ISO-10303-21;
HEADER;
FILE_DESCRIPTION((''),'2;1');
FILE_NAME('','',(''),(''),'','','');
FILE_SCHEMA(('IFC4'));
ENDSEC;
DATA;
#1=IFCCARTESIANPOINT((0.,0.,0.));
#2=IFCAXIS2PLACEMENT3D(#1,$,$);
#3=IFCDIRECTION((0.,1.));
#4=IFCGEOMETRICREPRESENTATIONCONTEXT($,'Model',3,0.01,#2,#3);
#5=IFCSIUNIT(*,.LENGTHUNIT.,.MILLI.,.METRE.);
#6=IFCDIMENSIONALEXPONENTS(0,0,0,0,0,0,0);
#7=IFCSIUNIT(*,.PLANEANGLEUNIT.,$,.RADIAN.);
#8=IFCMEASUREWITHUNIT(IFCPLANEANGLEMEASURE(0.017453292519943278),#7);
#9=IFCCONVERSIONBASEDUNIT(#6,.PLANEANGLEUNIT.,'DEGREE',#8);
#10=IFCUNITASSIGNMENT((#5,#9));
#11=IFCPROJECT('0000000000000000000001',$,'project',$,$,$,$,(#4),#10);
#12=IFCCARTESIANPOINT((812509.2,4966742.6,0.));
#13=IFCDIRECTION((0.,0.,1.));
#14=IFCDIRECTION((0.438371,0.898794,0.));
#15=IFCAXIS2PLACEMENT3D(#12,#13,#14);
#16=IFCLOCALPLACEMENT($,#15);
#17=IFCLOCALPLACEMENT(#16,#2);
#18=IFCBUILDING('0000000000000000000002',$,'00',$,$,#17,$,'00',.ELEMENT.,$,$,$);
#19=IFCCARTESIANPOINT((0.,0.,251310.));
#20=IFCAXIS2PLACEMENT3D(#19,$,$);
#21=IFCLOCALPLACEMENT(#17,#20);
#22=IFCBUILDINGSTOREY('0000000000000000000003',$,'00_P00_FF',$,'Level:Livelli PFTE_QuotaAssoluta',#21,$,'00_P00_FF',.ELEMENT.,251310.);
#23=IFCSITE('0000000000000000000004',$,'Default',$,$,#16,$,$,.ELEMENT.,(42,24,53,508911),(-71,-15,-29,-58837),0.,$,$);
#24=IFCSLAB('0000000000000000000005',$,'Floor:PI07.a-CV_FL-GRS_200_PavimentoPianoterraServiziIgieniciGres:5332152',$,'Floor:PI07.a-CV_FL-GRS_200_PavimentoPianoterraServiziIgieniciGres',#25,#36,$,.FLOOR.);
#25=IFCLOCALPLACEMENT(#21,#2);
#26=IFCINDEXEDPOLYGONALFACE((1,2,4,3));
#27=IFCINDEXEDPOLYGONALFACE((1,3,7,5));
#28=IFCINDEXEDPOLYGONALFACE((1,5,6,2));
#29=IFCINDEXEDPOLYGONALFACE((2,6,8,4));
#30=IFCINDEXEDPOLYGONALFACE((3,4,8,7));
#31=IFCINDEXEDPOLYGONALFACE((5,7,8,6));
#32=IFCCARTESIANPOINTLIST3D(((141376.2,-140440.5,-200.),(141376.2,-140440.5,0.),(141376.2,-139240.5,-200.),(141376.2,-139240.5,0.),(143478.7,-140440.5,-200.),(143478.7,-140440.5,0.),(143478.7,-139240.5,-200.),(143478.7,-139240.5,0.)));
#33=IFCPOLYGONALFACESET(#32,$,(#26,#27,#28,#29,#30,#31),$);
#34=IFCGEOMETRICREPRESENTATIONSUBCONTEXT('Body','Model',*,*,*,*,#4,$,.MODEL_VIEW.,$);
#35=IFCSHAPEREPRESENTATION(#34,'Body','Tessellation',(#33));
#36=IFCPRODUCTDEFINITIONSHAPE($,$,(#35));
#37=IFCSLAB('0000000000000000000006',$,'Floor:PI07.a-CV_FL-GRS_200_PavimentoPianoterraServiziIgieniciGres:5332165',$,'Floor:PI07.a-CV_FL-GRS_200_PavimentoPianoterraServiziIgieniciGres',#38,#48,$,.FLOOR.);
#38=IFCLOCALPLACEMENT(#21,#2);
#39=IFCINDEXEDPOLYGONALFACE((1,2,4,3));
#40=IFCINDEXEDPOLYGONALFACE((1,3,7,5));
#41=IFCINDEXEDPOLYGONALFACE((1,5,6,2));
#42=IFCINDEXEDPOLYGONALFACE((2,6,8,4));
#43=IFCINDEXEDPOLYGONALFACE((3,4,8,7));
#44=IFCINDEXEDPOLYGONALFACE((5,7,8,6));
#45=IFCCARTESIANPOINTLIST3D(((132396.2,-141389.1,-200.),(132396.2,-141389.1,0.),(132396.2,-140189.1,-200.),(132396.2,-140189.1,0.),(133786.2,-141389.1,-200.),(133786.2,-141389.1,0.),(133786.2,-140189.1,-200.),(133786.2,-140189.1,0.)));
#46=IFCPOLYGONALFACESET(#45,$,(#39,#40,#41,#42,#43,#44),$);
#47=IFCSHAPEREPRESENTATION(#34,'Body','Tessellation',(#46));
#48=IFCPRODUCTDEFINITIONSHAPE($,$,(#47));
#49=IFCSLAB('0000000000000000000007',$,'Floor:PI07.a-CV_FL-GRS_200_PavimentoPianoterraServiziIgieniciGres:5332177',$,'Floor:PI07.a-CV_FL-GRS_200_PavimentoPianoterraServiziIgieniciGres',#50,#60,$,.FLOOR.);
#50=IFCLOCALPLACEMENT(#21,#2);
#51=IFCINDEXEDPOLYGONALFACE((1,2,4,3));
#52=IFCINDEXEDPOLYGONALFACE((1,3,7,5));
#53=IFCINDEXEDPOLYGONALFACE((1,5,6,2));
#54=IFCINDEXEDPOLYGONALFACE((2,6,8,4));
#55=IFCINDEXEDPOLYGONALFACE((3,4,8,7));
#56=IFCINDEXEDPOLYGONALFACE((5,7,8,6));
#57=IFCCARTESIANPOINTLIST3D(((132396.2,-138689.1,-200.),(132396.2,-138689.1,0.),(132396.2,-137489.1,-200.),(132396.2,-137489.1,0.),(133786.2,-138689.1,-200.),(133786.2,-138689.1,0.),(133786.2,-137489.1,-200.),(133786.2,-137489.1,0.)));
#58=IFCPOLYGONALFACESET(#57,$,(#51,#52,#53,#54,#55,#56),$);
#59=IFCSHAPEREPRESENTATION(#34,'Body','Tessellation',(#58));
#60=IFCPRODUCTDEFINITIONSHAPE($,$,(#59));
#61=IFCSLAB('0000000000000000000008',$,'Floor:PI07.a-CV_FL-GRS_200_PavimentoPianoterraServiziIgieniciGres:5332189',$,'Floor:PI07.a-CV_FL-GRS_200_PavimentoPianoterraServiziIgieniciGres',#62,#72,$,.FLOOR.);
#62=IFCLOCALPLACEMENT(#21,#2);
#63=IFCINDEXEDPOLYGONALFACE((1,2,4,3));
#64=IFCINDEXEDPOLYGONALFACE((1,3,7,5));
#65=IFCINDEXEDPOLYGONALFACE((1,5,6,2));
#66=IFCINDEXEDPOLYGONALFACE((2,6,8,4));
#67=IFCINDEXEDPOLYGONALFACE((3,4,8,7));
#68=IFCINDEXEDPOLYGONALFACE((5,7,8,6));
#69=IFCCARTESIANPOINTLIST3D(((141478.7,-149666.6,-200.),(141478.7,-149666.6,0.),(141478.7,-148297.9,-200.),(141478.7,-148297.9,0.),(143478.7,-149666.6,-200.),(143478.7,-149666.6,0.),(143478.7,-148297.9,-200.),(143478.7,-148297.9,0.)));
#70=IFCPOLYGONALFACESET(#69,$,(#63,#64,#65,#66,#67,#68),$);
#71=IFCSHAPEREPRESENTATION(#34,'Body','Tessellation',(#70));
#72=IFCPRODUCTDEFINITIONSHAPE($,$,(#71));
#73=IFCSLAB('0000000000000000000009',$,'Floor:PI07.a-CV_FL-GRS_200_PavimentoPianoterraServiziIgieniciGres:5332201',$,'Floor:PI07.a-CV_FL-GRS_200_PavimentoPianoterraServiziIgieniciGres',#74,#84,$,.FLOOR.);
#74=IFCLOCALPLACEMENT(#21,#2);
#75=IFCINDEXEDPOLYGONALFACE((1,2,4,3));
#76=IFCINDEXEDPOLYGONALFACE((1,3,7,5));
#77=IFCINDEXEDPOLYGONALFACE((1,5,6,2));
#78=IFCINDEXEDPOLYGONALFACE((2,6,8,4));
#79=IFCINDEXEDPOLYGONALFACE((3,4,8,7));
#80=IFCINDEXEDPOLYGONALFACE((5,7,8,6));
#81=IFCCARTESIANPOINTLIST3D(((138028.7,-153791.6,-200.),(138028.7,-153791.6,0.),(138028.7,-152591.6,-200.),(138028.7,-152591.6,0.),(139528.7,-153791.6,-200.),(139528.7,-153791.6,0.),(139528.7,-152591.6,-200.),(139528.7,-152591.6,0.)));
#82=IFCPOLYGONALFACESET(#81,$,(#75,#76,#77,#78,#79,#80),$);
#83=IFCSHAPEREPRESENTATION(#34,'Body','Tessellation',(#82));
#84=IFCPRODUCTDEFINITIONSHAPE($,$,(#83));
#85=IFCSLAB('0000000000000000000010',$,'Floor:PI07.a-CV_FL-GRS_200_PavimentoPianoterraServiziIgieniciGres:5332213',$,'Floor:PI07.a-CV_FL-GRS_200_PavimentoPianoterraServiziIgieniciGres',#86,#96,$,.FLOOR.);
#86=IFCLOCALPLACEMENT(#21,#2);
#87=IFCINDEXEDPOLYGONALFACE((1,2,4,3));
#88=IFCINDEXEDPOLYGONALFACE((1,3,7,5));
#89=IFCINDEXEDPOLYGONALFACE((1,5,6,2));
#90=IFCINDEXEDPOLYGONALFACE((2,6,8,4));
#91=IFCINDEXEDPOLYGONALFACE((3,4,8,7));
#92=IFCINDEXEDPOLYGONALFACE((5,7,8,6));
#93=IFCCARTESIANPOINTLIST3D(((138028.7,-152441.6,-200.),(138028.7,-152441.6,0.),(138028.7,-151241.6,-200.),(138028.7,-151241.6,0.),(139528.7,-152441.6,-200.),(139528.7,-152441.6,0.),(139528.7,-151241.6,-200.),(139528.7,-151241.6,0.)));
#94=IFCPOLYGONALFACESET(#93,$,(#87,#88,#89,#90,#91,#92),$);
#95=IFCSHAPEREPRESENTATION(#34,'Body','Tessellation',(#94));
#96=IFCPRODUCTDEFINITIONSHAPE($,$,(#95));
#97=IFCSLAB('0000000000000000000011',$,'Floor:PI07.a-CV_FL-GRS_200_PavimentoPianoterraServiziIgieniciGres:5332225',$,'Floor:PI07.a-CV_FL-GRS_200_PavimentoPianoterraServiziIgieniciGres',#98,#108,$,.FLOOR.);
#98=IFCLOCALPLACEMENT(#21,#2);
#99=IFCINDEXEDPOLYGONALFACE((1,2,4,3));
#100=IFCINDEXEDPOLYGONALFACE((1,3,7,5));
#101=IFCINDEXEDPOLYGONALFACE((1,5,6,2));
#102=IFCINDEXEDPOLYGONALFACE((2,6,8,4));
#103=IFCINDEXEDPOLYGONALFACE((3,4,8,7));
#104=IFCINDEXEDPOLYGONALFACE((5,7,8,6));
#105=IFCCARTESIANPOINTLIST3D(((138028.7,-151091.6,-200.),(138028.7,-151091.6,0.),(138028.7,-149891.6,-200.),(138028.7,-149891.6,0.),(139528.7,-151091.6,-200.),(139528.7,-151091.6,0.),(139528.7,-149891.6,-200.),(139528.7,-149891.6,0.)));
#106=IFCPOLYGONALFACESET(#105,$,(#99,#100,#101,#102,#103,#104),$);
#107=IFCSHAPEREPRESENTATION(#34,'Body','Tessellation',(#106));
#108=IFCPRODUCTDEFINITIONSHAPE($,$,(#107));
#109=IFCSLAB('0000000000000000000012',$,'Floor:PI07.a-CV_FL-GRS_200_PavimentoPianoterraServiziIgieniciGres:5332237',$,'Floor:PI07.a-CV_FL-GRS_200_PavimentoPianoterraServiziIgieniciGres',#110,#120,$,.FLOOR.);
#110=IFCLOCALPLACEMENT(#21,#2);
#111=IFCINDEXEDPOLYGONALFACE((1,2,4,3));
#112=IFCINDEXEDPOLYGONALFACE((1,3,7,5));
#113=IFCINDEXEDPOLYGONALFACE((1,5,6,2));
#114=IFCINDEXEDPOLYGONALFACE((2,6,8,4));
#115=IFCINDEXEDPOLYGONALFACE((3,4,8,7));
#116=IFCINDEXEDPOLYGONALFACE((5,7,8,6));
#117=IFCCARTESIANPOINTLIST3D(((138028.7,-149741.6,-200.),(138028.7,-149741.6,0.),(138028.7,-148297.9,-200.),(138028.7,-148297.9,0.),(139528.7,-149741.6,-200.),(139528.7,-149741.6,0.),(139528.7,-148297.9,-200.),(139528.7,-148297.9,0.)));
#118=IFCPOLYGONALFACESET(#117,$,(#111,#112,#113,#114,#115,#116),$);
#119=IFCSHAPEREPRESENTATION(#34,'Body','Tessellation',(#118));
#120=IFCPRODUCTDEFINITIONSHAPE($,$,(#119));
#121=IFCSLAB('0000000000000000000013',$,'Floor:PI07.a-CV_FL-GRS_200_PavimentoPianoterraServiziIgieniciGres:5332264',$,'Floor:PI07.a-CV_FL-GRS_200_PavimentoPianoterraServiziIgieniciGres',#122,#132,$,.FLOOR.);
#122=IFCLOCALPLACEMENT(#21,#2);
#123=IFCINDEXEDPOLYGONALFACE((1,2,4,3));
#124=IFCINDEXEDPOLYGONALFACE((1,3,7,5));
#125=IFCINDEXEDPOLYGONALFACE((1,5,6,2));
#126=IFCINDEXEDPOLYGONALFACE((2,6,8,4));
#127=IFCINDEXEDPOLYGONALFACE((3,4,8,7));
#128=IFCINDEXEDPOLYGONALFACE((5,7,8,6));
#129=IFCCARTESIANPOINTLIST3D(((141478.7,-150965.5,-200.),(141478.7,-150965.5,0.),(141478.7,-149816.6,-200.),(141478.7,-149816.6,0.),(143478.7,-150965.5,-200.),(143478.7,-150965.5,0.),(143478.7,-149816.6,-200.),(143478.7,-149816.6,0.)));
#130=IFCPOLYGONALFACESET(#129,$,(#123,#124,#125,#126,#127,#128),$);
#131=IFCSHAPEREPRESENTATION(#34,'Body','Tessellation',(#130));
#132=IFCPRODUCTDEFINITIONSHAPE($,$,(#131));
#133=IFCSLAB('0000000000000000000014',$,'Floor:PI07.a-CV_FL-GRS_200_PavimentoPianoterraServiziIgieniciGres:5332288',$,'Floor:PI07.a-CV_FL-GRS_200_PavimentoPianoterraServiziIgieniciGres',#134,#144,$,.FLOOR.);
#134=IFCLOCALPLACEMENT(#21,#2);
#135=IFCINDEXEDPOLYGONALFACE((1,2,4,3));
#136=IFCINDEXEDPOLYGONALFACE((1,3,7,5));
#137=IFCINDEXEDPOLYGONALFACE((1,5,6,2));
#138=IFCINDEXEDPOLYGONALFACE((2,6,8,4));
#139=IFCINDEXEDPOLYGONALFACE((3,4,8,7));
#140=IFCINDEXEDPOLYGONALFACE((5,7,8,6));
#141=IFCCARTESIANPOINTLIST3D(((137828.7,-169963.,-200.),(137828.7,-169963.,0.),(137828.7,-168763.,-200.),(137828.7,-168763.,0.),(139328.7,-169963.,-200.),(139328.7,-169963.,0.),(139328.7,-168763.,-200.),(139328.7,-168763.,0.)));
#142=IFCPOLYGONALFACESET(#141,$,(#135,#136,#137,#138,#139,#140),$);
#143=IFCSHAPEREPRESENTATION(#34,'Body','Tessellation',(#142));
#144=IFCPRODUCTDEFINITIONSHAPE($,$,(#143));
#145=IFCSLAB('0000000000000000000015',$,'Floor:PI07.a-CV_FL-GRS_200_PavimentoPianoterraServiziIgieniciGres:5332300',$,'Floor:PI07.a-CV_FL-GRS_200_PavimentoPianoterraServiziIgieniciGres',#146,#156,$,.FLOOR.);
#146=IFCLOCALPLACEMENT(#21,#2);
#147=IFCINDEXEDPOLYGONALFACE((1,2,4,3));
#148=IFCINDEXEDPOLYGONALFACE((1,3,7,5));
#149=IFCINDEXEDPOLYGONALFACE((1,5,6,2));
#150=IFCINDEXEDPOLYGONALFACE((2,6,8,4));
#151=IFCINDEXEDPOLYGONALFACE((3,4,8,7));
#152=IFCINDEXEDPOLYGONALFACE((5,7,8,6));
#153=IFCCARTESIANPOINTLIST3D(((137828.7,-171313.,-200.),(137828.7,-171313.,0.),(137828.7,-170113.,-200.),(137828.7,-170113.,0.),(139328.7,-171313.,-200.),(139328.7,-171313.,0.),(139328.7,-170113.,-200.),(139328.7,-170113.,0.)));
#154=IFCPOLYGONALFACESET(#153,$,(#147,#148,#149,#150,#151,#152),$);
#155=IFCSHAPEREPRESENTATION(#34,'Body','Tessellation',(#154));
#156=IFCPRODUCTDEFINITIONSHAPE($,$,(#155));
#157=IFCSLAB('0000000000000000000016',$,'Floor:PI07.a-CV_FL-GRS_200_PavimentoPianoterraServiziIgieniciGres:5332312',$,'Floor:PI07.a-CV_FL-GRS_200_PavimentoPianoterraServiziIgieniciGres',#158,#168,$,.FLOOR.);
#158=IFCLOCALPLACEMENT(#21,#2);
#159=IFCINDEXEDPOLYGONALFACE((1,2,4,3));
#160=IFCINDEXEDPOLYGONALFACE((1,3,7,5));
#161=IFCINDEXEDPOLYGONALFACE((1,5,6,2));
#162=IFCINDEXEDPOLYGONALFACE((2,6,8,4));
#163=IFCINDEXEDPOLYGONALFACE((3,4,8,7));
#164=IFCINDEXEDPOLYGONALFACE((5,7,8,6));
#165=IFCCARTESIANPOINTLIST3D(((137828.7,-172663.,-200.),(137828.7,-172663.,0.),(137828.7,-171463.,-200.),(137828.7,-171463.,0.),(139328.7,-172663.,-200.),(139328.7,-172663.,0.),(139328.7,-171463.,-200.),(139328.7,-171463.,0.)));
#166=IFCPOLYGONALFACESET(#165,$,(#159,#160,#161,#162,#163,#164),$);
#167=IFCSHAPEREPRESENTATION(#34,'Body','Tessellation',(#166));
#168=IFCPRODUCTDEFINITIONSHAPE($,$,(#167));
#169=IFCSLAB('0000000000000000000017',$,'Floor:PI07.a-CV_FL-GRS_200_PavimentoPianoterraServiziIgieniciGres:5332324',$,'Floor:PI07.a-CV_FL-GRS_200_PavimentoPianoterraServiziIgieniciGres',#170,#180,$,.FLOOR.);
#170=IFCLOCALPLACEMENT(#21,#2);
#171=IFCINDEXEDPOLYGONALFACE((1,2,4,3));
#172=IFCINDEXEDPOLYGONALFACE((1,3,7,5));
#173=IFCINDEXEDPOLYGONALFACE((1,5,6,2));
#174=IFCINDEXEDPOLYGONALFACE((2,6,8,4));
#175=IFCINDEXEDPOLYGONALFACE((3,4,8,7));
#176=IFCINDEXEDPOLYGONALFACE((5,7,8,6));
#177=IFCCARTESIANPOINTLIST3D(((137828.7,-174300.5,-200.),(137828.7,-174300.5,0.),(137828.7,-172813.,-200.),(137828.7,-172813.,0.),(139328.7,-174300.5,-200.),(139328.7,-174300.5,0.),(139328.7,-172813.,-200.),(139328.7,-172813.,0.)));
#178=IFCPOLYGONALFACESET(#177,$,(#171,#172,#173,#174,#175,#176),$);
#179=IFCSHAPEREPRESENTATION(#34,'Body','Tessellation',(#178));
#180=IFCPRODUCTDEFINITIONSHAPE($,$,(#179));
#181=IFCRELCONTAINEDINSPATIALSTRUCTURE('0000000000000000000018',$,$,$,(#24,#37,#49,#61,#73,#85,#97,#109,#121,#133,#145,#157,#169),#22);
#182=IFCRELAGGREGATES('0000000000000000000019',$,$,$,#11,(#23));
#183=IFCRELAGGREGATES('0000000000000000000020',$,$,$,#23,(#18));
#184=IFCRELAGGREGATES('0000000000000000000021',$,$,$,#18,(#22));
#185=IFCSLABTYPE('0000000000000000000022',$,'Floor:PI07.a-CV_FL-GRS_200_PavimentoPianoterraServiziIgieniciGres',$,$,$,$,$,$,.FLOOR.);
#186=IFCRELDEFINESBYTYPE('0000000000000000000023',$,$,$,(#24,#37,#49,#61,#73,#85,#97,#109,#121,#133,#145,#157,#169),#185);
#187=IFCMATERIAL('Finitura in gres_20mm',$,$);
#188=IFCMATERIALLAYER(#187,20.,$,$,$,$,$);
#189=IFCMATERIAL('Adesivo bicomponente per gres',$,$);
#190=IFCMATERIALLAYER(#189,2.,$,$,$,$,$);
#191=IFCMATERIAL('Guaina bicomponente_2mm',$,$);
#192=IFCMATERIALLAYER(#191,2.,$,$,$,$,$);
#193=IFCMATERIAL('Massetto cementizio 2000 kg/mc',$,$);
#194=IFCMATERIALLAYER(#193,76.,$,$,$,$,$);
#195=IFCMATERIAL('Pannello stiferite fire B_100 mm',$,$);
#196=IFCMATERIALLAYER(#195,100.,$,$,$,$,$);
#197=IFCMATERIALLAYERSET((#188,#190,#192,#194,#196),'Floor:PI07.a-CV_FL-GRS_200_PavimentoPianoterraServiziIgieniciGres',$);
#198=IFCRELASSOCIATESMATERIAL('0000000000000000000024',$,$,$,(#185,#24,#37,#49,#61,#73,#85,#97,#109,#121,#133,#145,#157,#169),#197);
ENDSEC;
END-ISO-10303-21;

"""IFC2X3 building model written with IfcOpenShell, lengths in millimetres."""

from ifc_helpers import new_model, entity, si_unit, converted_unit, direction, frame, frame_2d, origin, origin_2d_with_axis, place, context, subcontext, project, spatial, rectangle, extrude, material, layer, layer_set, layer_usage, type_object, element, save


model = new_model("IFC2X3")

# Units and contexts
model_context = context("Model", 3, precision=0.01, world=origin(), true_north=direction((0.0, 1.0)))
body_context = subcontext(model_context, "Body", "Model", "MODEL_VIEW")
ifc_project = project(units=[si_unit("LENGTHUNIT", "METRE", prefix="MILLI"), converted_unit("PLANEANGLEUNIT", "DEGREE", entity("IfcPlaneAngleMeasure", 0.017453292519943278), si_unit("PLANEANGLEUNIT", "RADIAN"), dimensions=[0, 0, 0, 0, 0, 0, 0])], contexts=[model_context])

# Site, building, storey
site_placement = place(None, frame((812509.2, 4966742.6, 0.0), z_axis=(0.0, 0.0, 1.0), x_axis=(0.438371, 0.898794, 0.0)))
site = spatial("IfcSite", under=ifc_project, at=site_placement, Name="Default", CompositionType="ELEMENT", RefLatitude=(42, 24, 53, 508911), RefLongitude=(-71, -15, -29, -58837), RefElevation=0.0)
building_placement = place(site_placement, origin())
building = spatial("IfcBuilding", under=site, at=building_placement, Name="00", LongName="00", CompositionType="ELEMENT")
storey_placement = place(building_placement, frame((0.0, 0.0, 251310.0)))
storey = spatial("IfcBuildingStorey", under=building, at=storey_placement, Name="00_P00_FF", ObjectType="Level:Livelli PFTE_QuotaAssoluta", LongName="00_P00_FF", CompositionType="ELEMENT", Elevation=251310.0)

# Slabs
ifc_material_1 = material(Name="Finitura in gres_20mm")
ifc_layer_1 = layer(ifc_material_1, 20.0)
ifc_material_2 = material(Name="Adesivo bicomponente per gres")
ifc_layer_2 = layer(ifc_material_2, 2.0)
ifc_material_3 = material(Name="Guaina bicomponente_2mm")
ifc_layer_3 = layer(ifc_material_3, 2.0)
ifc_material_4 = material(Name="Massetto cementizio 2000 kg/mc")
ifc_layer_4 = layer(ifc_material_4, 76.0)
ifc_material_5 = material(Name="Pannello stiferite fire B_100 mm")
ifc_layer_5 = layer(ifc_material_5, 100.0)
ifc_layer_set = layer_set([ifc_layer_1, ifc_layer_2, ifc_layer_3, ifc_layer_4, ifc_layer_5], Name="Floor:PI07.a-CV_FL-GRS_200_PavimentoPianoterraServiziIgieniciGres")
ifc_layer_usage_1 = layer_usage(ifc_layer_set, "AXIS3", "POSITIVE", 0.0)
slab_type = type_object("IfcSlabType", Name="Floor:PI07.a-CV_FL-GRS_200_PavimentoPianoterraServiziIgieniciGres", PredefinedType="FLOOR", material=ifc_layer_set)
slab_1_placement = place(storey_placement, origin())
element("IfcSlab", 1, at=slab_1_placement, inside=storey, type_object=slab_type, material=ifc_layer_usage_1, Name="Floor:PI07.a-CV_FL-GRS_200_PavimentoPianoterraServiziIgieniciGres:5332152", ObjectType="Floor:PI07.a-CV_FL-GRS_200_PavimentoPianoterraServiziIgieniciGres", PredefinedType="FLOOR", context=body_context, shape_type="SweptSolid", body=[
    extrude(rectangle(XDim=1200.0, YDim=2102.5, at=origin_2d_with_axis()), frame((142427.4, -139840.5, 0.0), z_axis=(0.0, 0.0, -1.0), x_axis=(0.0, 1.0, 0.0)), (0.0, 0.0, 1.0), 200.0),
])
ifc_layer_usage_2 = layer_usage(ifc_layer_set, "AXIS3", "POSITIVE", 0.0)
slab_2_placement = place(storey_placement, origin())
element("IfcSlab", 2, at=slab_2_placement, inside=storey, type_object=slab_type, material=ifc_layer_usage_2, Name="Floor:PI07.a-CV_FL-GRS_200_PavimentoPianoterraServiziIgieniciGres:5332165", ObjectType="Floor:PI07.a-CV_FL-GRS_200_PavimentoPianoterraServiziIgieniciGres", PredefinedType="FLOOR", context=body_context, shape_type="SweptSolid", body=[
    extrude(rectangle(XDim=1200.0, YDim=1390.0, at=frame_2d((0.0, 0.0), x_axis=(1.0, 0.0))), frame((133091.2, -140789.1, 0.0), z_axis=(0.0, 0.0, -1.0), x_axis=(0.0, 1.0, 0.0)), (0.0, 0.0, 1.0), 200.0),
])
ifc_layer_usage_3 = layer_usage(ifc_layer_set, "AXIS3", "POSITIVE", 0.0)
slab_3_placement = place(storey_placement, origin())
element("IfcSlab", 3, at=slab_3_placement, inside=storey, type_object=slab_type, material=ifc_layer_usage_3, Name="Floor:PI07.a-CV_FL-GRS_200_PavimentoPianoterraServiziIgieniciGres:5332177", ObjectType="Floor:PI07.a-CV_FL-GRS_200_PavimentoPianoterraServiziIgieniciGres", PredefinedType="FLOOR", context=body_context, shape_type="SweptSolid", body=[
    extrude(rectangle(XDim=1200.0, YDim=1390.0, at=origin_2d_with_axis()), frame((133091.2, -138089.1, 0.0), z_axis=(0.0, 0.0, -1.0), x_axis=(0.0, 1.0, 0.0)), (0.0, 0.0, 1.0), 200.0),
])
ifc_layer_usage_4 = layer_usage(ifc_layer_set, "AXIS3", "POSITIVE", 0.0)
slab_4_placement = place(storey_placement, origin())
element("IfcSlab", 4, at=slab_4_placement, inside=storey, type_object=slab_type, material=ifc_layer_usage_4, Name="Floor:PI07.a-CV_FL-GRS_200_PavimentoPianoterraServiziIgieniciGres:5332189", ObjectType="Floor:PI07.a-CV_FL-GRS_200_PavimentoPianoterraServiziIgieniciGres", PredefinedType="FLOOR", context=body_context, shape_type="SweptSolid", body=[
    extrude(rectangle(XDim=1368.7, YDim=2000.0, at=frame_2d((0.0, 0.0), x_axis=(1.0, 0.0))), frame((142478.7, -148982.3, 0.0), z_axis=(0.0, 0.0, -1.0), x_axis=(0.0, 1.0, 0.0)), (0.0, 0.0, 1.0), 200.0),
])
ifc_layer_usage_5 = layer_usage(ifc_layer_set, "AXIS3", "POSITIVE", 0.0)
slab_5_placement = place(storey_placement, origin())
element("IfcSlab", 5, at=slab_5_placement, inside=storey, type_object=slab_type, material=ifc_layer_usage_5, Name="Floor:PI07.a-CV_FL-GRS_200_PavimentoPianoterraServiziIgieniciGres:5332201", ObjectType="Floor:PI07.a-CV_FL-GRS_200_PavimentoPianoterraServiziIgieniciGres", PredefinedType="FLOOR", context=body_context, shape_type="SweptSolid", body=[
    extrude(rectangle(XDim=1200.0, YDim=1500.0, at=frame_2d((0.0, 0.0), x_axis=(1.0, 0.0))), frame((138778.7, -153191.6, 0.0), z_axis=(0.0, 0.0, -1.0), x_axis=(0.0, 1.0, 0.0)), (0.0, 0.0, 1.0), 200.0),
])
ifc_layer_usage_6 = layer_usage(ifc_layer_set, "AXIS3", "POSITIVE", 0.0)
slab_6_placement = place(storey_placement, origin())
element("IfcSlab", 6, at=slab_6_placement, inside=storey, type_object=slab_type, material=ifc_layer_usage_6, Name="Floor:PI07.a-CV_FL-GRS_200_PavimentoPianoterraServiziIgieniciGres:5332213", ObjectType="Floor:PI07.a-CV_FL-GRS_200_PavimentoPianoterraServiziIgieniciGres", PredefinedType="FLOOR", context=body_context, shape_type="SweptSolid", body=[
    extrude(rectangle(XDim=1200.0, YDim=1500.0, at=origin_2d_with_axis()), frame((138778.7, -151841.6, 0.0), z_axis=(0.0, 0.0, -1.0), x_axis=(0.0, 1.0, 0.0)), (0.0, 0.0, 1.0), 200.0),
])
ifc_layer_usage_7 = layer_usage(ifc_layer_set, "AXIS3", "POSITIVE", 0.0)
slab_7_placement = place(storey_placement, origin())
element("IfcSlab", 7, at=slab_7_placement, inside=storey, type_object=slab_type, material=ifc_layer_usage_7, Name="Floor:PI07.a-CV_FL-GRS_200_PavimentoPianoterraServiziIgieniciGres:5332225", ObjectType="Floor:PI07.a-CV_FL-GRS_200_PavimentoPianoterraServiziIgieniciGres", PredefinedType="FLOOR", context=body_context, shape_type="SweptSolid", body=[
    extrude(rectangle(XDim=1200.0, YDim=1500.0, at=origin_2d_with_axis()), frame((138778.7, -150491.6, 0.0), z_axis=(0.0, 0.0, -1.0), x_axis=(0.0, 1.0, 0.0)), (0.0, 0.0, 1.0), 200.0),
])
ifc_layer_usage_8 = layer_usage(ifc_layer_set, "AXIS3", "POSITIVE", 0.0)
slab_8_placement = place(storey_placement, origin())
element("IfcSlab", 8, at=slab_8_placement, inside=storey, type_object=slab_type, material=ifc_layer_usage_8, Name="Floor:PI07.a-CV_FL-GRS_200_PavimentoPianoterraServiziIgieniciGres:5332237", ObjectType="Floor:PI07.a-CV_FL-GRS_200_PavimentoPianoterraServiziIgieniciGres", PredefinedType="FLOOR", context=body_context, shape_type="SweptSolid", body=[
    extrude(rectangle(XDim=1443.7, YDim=1500.0, at=frame_2d((0.0, 0.0), x_axis=(1.0, 0.0))), frame((138778.7, -149019.8, 0.0), z_axis=(0.0, 0.0, -1.0), x_axis=(0.0, 1.0, 0.0)), (0.0, 0.0, 1.0), 200.0),
])
ifc_layer_usage_9 = layer_usage(ifc_layer_set, "AXIS3", "POSITIVE", 0.0)
slab_9_placement = place(storey_placement, origin())
element("IfcSlab", 9, at=slab_9_placement, inside=storey, type_object=slab_type, material=ifc_layer_usage_9, Name="Floor:PI07.a-CV_FL-GRS_200_PavimentoPianoterraServiziIgieniciGres:5332264", ObjectType="Floor:PI07.a-CV_FL-GRS_200_PavimentoPianoterraServiziIgieniciGres", PredefinedType="FLOOR", context=body_context, shape_type="SweptSolid", body=[
    extrude(rectangle(XDim=1148.8, YDim=2000.0, at=frame_2d((0.0, 0.0), x_axis=(1.0, 0.0))), frame((142478.7, -150391.1, 0.0), z_axis=(0.0, 0.0, -1.0), x_axis=(0.0, 1.0, 0.0)), (0.0, 0.0, 1.0), 200.0),
])
ifc_layer_usage_10 = layer_usage(ifc_layer_set, "AXIS3", "POSITIVE", 0.0)
slab_10_placement = place(storey_placement, origin())
element("IfcSlab", 10, at=slab_10_placement, inside=storey, type_object=slab_type, material=ifc_layer_usage_10, Name="Floor:PI07.a-CV_FL-GRS_200_PavimentoPianoterraServiziIgieniciGres:5332288", ObjectType="Floor:PI07.a-CV_FL-GRS_200_PavimentoPianoterraServiziIgieniciGres", PredefinedType="FLOOR", context=body_context, shape_type="SweptSolid", body=[
    extrude(rectangle(XDim=1200.0, YDim=1500.0, at=frame_2d((0.0, 0.0), x_axis=(1.0, 0.0))), frame((138578.7, -169363.0, 0.0), z_axis=(0.0, 0.0, -1.0), x_axis=(0.0, 1.0, 0.0)), (0.0, 0.0, 1.0), 200.0),
])
ifc_layer_usage_11 = layer_usage(ifc_layer_set, "AXIS3", "POSITIVE", 0.0)
slab_11_placement = place(storey_placement, origin())
element("IfcSlab", 11, at=slab_11_placement, inside=storey, type_object=slab_type, material=ifc_layer_usage_11, Name="Floor:PI07.a-CV_FL-GRS_200_PavimentoPianoterraServiziIgieniciGres:5332300", ObjectType="Floor:PI07.a-CV_FL-GRS_200_PavimentoPianoterraServiziIgieniciGres", PredefinedType="FLOOR", context=body_context, shape_type="SweptSolid", body=[
    extrude(rectangle(XDim=1200.0, YDim=1500.0, at=frame_2d((0.0, 0.0), x_axis=(1.0, 0.0))), frame((138578.7, -170713.0, 0.0), z_axis=(0.0, 0.0, -1.0), x_axis=(0.0, 1.0, 0.0)), (0.0, 0.0, 1.0), 200.0),
])
ifc_layer_usage_12 = layer_usage(ifc_layer_set, "AXIS3", "POSITIVE", 0.0)
slab_12_placement = place(storey_placement, origin())
element("IfcSlab", 12, at=slab_12_placement, inside=storey, type_object=slab_type, material=ifc_layer_usage_12, Name="Floor:PI07.a-CV_FL-GRS_200_PavimentoPianoterraServiziIgieniciGres:5332312", ObjectType="Floor:PI07.a-CV_FL-GRS_200_PavimentoPianoterraServiziIgieniciGres", PredefinedType="FLOOR", context=body_context, shape_type="SweptSolid", body=[
    extrude(rectangle(XDim=1200.0, YDim=1500.0, at=frame_2d((0.0, 0.0), x_axis=(1.0, 0.0))), frame((138578.7, -172063.0, 0.0), z_axis=(0.0, 0.0, -1.0), x_axis=(0.0, 1.0, 0.0)), (0.0, 0.0, 1.0), 200.0),
])
ifc_layer_usage_13 = layer_usage(ifc_layer_set, "AXIS3", "POSITIVE", 0.0)
slab_13_placement = place(storey_placement, origin())
element("IfcSlab", 13, at=slab_13_placement, inside=storey, type_object=slab_type, material=ifc_layer_usage_13, Name="Floor:PI07.a-CV_FL-GRS_200_PavimentoPianoterraServiziIgieniciGres:5332324", ObjectType="Floor:PI07.a-CV_FL-GRS_200_PavimentoPianoterraServiziIgieniciGres", PredefinedType="FLOOR", context=body_context, shape_type="SweptSolid", body=[
    extrude(rectangle(XDim=1487.5, YDim=1500.0, at=frame_2d((0.0, 0.0), x_axis=(1.0, 0.0))), frame((138578.7, -173556.7, 0.0), z_axis=(0.0, 0.0, -1.0), x_axis=(0.0, 1.0, 0.0)), (0.0, 0.0, 1.0), 200.0),
])

save(model, "model.ifc")
